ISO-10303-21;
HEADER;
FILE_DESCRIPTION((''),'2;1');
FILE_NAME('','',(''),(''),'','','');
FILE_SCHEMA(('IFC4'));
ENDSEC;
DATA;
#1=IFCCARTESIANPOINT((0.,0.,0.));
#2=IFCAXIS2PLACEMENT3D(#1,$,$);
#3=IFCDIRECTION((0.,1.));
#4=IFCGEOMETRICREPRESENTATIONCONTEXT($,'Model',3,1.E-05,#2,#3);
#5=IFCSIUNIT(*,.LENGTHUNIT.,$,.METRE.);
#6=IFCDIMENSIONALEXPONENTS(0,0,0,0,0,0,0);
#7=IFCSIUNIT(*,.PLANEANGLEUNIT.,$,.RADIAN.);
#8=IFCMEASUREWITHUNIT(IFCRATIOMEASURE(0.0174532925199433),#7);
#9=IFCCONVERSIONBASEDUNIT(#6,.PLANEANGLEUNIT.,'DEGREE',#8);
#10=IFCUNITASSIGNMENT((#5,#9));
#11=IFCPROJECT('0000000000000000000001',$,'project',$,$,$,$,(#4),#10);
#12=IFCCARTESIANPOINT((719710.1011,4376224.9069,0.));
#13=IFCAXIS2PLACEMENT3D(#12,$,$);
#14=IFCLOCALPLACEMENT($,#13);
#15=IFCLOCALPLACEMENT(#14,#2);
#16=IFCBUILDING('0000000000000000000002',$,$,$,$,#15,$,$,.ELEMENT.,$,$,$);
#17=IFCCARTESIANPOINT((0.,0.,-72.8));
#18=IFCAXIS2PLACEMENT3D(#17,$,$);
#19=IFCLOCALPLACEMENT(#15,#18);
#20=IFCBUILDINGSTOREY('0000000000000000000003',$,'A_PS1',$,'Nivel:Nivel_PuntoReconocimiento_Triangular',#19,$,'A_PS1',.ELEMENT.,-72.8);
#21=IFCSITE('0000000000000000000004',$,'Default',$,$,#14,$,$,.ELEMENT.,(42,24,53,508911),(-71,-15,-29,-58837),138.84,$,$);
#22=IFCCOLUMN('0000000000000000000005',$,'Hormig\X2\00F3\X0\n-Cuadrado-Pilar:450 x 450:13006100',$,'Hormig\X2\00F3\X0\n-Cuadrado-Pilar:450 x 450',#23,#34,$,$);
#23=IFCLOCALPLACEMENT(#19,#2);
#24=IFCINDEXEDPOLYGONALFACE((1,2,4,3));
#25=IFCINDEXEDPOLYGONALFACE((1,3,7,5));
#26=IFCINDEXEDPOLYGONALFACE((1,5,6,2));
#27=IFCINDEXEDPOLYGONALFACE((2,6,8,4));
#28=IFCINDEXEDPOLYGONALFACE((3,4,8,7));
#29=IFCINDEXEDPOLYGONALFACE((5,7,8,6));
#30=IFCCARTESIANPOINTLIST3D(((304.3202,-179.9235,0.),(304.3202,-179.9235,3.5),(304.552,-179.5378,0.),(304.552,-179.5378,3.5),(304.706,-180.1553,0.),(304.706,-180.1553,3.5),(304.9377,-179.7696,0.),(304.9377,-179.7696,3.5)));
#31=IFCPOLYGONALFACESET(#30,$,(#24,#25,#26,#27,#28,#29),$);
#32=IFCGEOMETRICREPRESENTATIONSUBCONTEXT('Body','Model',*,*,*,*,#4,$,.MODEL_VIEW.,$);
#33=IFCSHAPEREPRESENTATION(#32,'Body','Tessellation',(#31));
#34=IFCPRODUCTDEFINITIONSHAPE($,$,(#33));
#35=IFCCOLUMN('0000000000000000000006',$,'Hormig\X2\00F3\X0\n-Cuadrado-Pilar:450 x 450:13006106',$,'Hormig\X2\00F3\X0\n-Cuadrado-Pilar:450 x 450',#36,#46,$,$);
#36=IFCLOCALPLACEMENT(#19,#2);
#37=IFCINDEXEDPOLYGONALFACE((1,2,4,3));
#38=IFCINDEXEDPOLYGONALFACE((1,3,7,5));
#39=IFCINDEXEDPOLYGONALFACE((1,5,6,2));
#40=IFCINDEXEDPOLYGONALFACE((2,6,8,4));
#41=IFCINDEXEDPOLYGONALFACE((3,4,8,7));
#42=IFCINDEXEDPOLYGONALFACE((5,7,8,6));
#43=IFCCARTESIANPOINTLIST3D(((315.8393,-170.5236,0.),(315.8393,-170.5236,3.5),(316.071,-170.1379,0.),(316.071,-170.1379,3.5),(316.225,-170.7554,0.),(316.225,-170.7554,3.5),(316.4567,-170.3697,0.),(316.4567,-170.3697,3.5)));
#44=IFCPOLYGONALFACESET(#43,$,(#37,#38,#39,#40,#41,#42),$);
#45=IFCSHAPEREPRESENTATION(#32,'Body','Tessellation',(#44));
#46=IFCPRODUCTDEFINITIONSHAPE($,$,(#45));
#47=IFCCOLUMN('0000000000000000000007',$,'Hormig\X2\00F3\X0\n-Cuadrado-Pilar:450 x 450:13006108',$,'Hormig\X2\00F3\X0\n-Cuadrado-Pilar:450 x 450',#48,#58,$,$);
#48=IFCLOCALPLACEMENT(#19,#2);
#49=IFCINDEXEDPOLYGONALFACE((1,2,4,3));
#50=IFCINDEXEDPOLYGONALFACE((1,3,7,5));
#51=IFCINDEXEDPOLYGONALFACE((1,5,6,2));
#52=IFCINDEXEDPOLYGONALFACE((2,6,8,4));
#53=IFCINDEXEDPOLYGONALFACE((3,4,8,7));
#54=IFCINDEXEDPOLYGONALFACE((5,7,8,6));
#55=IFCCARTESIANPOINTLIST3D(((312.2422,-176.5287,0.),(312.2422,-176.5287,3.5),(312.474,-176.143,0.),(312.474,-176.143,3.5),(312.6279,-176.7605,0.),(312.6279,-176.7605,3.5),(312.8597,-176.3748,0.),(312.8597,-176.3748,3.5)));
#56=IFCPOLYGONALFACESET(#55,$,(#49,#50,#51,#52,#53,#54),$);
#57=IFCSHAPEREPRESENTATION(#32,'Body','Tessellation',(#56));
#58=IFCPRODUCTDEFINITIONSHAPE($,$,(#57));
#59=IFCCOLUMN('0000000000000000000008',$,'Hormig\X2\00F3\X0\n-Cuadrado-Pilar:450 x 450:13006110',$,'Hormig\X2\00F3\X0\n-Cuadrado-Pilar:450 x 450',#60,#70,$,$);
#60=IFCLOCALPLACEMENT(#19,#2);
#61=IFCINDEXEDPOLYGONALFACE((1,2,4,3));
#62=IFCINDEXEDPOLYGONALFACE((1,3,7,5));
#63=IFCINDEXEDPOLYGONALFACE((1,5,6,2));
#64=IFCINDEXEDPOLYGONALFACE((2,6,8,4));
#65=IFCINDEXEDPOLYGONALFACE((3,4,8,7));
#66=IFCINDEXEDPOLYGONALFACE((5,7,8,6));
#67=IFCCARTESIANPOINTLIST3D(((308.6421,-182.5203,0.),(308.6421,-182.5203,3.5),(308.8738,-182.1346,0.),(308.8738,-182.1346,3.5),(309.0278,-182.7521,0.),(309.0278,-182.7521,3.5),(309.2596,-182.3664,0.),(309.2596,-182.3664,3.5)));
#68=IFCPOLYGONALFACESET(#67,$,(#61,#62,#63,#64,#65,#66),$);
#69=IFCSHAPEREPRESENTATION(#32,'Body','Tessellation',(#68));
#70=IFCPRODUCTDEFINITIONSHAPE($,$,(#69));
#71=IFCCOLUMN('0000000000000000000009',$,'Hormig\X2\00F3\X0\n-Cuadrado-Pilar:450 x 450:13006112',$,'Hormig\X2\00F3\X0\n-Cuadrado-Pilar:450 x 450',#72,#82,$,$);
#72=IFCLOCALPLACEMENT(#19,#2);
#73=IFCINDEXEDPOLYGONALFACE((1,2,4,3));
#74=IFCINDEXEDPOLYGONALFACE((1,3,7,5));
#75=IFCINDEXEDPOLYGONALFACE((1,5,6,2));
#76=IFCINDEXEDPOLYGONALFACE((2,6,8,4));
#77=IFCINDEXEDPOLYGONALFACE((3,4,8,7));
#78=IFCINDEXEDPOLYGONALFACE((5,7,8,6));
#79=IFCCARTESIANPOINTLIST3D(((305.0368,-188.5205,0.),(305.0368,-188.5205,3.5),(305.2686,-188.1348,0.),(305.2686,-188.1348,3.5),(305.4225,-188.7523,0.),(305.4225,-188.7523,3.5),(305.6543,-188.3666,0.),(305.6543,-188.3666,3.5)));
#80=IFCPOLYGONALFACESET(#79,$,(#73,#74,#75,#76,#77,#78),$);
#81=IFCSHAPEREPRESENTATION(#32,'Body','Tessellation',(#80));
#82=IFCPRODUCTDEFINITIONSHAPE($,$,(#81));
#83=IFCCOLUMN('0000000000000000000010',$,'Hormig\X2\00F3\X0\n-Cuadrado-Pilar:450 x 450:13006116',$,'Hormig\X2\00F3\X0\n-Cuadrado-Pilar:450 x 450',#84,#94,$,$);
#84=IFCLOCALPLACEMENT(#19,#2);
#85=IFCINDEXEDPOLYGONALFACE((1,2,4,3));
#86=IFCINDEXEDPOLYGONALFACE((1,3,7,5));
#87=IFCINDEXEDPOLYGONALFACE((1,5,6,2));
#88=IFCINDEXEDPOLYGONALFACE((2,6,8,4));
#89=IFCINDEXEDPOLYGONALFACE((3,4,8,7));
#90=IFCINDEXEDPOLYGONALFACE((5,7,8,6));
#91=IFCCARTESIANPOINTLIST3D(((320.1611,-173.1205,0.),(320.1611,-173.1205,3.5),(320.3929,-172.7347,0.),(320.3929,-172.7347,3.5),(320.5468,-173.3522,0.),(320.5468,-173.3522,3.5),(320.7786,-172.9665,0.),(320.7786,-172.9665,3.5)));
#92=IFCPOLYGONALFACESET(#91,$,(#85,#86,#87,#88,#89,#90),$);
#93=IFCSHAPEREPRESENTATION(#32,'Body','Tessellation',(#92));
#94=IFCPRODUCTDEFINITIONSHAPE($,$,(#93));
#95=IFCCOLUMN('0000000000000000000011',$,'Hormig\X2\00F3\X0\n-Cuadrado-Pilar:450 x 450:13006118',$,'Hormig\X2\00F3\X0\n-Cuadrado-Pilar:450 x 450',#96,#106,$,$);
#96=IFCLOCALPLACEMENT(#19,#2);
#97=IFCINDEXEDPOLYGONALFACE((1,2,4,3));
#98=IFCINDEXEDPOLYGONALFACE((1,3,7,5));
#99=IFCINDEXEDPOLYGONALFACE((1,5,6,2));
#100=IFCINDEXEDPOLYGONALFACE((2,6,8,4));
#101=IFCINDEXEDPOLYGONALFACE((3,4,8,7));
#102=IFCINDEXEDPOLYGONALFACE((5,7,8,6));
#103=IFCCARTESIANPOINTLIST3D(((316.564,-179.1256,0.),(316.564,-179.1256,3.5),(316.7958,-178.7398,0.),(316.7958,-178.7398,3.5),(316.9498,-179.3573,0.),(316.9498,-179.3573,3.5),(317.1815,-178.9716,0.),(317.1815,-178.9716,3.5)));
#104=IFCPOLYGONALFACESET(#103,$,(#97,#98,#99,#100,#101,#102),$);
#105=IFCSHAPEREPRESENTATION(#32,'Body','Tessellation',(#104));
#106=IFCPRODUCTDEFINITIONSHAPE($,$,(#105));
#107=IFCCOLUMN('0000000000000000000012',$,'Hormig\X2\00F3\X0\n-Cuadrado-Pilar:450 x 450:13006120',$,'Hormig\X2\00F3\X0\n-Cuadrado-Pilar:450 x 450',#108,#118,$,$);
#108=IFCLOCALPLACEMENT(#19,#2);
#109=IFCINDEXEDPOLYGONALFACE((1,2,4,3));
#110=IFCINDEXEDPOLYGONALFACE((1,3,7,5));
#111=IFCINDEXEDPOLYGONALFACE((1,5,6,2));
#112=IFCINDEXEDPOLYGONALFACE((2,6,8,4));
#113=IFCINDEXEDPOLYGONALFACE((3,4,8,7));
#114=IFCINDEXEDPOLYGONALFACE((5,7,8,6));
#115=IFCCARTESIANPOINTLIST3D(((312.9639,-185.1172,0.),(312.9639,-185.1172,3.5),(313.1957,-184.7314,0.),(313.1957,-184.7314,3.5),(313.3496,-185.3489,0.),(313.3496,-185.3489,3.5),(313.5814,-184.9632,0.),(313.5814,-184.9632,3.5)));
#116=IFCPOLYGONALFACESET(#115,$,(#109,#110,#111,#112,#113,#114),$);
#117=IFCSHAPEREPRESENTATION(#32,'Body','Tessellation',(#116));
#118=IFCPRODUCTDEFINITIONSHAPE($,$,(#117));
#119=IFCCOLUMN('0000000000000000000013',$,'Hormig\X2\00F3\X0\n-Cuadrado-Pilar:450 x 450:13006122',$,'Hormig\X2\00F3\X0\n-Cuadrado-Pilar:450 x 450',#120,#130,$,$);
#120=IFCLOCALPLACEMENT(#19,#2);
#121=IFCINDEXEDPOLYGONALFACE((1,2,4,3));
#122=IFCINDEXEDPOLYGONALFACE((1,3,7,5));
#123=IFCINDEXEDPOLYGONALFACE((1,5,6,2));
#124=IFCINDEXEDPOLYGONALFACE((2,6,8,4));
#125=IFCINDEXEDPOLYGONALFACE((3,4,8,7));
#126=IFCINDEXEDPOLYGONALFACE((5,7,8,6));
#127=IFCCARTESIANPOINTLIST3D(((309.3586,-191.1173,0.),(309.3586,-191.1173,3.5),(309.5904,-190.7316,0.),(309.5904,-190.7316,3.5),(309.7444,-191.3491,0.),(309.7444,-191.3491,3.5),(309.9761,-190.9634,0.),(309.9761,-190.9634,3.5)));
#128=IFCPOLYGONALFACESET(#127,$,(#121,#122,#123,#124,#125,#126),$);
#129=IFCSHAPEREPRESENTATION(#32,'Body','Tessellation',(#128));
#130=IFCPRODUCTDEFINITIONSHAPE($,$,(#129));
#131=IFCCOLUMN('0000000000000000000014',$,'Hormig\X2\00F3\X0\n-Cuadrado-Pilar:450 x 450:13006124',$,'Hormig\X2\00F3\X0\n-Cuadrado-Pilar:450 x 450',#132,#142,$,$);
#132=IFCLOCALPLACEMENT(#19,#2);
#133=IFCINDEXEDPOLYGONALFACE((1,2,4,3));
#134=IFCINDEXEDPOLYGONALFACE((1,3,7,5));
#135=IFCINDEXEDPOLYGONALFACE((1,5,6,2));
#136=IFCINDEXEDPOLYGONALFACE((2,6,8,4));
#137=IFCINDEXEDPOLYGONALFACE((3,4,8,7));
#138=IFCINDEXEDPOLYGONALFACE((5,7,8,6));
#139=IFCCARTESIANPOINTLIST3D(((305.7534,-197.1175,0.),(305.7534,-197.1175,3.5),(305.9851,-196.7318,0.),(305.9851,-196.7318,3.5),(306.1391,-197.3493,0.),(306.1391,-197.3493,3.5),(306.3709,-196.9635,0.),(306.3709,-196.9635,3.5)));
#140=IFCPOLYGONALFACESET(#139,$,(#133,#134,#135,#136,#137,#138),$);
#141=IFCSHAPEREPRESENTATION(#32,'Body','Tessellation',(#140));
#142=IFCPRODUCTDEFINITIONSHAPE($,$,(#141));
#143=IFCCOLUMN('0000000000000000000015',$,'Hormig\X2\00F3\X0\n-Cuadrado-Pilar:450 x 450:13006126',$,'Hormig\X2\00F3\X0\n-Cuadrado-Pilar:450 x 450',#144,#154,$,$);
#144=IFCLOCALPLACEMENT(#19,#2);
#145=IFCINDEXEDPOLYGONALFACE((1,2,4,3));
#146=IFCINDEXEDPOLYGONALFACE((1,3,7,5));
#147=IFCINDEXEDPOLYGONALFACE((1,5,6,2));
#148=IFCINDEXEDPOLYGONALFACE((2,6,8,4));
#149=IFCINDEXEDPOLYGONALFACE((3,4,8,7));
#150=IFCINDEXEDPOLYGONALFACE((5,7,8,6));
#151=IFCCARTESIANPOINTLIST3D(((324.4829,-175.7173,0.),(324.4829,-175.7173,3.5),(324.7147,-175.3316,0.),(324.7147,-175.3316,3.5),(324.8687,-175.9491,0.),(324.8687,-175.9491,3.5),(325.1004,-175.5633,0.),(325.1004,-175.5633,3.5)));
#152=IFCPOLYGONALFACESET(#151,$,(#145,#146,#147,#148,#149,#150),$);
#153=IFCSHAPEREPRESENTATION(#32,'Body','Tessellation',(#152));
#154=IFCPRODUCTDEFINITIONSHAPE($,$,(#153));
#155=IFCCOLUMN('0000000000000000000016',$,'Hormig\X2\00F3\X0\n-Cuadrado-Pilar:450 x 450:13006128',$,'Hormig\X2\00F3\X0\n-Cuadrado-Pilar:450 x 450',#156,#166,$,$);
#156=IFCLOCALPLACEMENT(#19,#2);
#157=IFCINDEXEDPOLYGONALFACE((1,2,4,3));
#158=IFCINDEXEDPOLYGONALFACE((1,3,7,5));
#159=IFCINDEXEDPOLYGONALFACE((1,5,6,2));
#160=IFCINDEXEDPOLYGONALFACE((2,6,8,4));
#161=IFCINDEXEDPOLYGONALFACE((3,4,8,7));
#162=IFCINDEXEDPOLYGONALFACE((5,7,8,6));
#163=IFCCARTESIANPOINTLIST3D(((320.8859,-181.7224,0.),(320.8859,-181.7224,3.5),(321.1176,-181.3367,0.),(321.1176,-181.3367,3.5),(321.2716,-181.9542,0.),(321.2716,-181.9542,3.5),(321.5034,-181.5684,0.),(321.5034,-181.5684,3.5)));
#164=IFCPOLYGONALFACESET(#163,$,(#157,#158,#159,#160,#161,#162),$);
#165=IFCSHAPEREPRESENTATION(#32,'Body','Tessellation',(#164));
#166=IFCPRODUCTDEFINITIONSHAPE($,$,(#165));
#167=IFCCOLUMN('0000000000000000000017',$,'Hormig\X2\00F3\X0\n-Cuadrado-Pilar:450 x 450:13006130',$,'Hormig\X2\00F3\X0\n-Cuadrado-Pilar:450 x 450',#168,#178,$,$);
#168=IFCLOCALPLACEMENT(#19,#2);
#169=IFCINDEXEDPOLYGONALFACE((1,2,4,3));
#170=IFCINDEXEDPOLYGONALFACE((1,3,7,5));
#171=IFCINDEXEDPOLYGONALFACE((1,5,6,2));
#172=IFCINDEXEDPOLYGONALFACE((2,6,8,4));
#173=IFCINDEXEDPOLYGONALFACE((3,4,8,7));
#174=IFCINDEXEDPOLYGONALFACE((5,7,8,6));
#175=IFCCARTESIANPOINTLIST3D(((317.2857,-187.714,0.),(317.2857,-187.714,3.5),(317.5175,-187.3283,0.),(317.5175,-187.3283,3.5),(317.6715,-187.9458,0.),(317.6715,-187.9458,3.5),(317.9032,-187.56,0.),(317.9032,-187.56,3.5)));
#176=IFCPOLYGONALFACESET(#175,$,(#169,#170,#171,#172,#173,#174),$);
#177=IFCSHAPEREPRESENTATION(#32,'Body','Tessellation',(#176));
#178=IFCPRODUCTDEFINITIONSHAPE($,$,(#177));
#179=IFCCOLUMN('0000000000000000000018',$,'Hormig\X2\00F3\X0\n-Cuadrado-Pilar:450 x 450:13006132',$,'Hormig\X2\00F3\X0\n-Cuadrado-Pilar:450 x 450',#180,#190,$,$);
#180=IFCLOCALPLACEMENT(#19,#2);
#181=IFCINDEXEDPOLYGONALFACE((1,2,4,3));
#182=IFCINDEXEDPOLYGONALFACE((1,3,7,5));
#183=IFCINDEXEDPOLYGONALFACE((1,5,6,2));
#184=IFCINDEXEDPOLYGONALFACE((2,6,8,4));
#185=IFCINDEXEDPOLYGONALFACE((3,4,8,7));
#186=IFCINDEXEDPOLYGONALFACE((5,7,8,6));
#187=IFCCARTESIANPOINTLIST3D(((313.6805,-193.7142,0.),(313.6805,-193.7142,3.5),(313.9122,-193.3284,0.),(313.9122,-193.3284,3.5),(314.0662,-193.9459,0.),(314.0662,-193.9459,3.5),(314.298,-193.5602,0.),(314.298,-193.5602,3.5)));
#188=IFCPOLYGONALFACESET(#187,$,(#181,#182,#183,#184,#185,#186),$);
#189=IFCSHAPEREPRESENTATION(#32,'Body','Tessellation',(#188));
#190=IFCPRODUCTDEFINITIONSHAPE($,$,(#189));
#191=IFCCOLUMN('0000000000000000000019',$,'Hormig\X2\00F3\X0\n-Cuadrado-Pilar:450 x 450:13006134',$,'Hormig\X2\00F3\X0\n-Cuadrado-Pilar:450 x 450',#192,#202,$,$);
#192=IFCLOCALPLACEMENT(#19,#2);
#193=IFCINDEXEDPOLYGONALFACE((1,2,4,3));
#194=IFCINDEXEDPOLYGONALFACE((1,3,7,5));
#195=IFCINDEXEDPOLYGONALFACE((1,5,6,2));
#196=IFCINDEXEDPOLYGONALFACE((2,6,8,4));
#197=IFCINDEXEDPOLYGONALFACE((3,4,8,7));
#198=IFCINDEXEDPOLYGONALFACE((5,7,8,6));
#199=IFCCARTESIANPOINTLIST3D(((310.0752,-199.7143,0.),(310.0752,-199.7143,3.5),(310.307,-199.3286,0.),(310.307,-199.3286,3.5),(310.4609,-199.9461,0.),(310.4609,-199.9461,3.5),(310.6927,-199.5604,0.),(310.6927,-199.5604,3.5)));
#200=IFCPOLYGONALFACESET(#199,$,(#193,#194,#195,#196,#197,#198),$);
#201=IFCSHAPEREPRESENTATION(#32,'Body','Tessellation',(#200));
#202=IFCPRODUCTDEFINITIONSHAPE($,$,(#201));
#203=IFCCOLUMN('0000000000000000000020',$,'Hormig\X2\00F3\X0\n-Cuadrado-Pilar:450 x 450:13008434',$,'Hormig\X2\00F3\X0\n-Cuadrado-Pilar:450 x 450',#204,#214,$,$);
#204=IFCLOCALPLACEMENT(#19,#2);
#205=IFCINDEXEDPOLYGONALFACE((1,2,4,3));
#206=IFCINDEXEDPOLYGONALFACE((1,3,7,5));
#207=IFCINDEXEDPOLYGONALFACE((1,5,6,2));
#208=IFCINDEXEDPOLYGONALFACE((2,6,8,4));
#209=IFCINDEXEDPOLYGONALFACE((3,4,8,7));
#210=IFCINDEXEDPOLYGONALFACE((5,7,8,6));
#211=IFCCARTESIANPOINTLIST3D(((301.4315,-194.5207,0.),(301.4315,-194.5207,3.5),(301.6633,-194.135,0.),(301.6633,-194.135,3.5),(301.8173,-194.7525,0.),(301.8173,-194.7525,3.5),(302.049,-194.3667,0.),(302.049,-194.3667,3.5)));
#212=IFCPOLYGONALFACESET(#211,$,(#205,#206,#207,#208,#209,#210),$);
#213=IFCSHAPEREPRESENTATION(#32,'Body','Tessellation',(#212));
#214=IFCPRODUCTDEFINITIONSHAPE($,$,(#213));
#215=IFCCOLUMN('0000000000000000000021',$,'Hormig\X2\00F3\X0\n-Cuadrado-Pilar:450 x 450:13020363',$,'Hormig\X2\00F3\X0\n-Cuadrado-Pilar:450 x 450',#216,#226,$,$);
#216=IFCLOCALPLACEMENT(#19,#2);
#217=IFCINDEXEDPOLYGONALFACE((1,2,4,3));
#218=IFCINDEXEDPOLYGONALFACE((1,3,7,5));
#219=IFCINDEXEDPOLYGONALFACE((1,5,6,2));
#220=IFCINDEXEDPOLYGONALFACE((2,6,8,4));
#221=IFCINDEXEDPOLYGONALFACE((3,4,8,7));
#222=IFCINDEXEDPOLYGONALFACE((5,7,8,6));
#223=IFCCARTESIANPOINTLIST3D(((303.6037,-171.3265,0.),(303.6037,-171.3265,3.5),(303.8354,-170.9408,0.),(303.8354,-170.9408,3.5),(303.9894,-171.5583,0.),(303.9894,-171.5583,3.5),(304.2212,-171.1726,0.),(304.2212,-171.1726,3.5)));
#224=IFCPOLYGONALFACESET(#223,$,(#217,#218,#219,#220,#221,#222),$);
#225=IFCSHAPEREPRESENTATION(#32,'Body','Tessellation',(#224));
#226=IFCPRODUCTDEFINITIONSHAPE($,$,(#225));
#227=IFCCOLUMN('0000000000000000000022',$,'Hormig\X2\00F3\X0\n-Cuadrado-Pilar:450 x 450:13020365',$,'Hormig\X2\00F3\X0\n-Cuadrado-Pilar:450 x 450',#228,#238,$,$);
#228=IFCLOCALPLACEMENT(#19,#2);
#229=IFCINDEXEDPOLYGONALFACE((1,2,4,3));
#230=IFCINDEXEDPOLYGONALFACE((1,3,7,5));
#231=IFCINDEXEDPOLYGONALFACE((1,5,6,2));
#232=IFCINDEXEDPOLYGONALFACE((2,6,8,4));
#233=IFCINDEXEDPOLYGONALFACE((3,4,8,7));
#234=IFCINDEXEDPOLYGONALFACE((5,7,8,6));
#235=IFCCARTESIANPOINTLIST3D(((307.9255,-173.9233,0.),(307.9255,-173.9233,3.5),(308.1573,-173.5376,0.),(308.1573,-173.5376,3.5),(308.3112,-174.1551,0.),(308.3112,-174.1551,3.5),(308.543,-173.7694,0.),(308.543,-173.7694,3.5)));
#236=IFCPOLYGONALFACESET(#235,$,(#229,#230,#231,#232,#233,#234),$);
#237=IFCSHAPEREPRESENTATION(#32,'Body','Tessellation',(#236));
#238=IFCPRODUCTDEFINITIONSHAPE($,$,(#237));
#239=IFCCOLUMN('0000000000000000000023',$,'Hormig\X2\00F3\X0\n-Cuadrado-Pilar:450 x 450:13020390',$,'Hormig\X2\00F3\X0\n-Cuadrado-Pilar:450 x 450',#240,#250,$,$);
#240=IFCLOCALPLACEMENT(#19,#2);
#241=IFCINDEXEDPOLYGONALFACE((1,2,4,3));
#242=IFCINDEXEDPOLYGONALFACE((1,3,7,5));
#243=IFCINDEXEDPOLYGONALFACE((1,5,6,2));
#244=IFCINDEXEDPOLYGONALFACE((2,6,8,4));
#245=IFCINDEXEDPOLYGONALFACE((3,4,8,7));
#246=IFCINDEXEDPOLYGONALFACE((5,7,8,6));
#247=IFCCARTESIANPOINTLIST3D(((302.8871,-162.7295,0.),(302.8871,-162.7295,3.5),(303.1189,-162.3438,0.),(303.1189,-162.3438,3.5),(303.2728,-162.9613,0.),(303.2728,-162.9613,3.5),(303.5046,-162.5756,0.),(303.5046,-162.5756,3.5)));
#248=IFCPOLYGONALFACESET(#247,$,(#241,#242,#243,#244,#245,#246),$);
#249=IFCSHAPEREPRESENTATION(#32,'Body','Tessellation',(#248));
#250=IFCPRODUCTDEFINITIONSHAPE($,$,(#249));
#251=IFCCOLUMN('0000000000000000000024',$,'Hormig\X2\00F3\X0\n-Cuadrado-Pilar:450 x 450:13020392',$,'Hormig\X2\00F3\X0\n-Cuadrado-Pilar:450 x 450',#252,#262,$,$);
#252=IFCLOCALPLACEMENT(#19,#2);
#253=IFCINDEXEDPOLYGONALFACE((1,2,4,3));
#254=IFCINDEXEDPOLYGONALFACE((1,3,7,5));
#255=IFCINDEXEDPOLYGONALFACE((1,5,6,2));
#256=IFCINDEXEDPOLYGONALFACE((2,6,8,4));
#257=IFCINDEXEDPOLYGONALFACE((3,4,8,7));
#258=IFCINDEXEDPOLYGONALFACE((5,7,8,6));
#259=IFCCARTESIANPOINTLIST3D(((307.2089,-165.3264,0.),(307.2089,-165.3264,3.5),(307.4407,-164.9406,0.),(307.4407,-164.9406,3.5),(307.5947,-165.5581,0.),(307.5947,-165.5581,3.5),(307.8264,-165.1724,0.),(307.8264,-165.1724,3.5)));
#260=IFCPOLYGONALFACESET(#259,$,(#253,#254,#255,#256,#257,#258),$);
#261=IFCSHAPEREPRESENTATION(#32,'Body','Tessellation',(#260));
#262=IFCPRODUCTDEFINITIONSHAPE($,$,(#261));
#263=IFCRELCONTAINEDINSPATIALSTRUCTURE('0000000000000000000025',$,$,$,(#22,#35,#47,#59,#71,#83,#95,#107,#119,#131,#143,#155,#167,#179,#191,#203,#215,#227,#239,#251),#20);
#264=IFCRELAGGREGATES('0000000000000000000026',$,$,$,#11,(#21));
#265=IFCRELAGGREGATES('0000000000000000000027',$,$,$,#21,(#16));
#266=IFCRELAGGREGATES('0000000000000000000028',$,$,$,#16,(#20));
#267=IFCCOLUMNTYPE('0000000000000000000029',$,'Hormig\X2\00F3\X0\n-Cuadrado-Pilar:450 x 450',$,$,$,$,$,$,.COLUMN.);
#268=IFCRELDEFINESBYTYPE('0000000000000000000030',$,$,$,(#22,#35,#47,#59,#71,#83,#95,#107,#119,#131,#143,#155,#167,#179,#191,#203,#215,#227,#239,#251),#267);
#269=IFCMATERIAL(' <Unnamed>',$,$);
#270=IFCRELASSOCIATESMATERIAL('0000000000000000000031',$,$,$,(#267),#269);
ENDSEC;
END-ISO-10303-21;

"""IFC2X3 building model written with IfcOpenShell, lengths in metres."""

from ifc_helpers import new_model, entity, si_unit, converted_unit, direction, frame, origin, origin_2d_with_axis, place, context, subcontext, project, spatial, rectangle, extrude, source, transform, mapped, material, type_object, type_shapes, element, save


model = new_model("IFC2X3")

# Units and contexts
model_context = context("Model", 3, precision=1e-05, world=origin(), true_north=direction((0.0, 1.0)))
body_context = subcontext(model_context, "Body", "Model", "MODEL_VIEW")
ifc_project = project(units=[si_unit("LENGTHUNIT", "METRE"), converted_unit("PLANEANGLEUNIT", "DEGREE", entity("IfcRatioMeasure", 0.0174532925199433), si_unit("PLANEANGLEUNIT", "RADIAN"), dimensions=[0, 0, 0, 0, 0, 0, 0])], contexts=[model_context])

# Site, building, storey
site_placement = place(None, frame((719710.1011, 4376224.9069, 0.0)))
site = spatial("IfcSite", under=ifc_project, at=site_placement, Name="Default", CompositionType="ELEMENT", RefLatitude=(42, 24, 53, 508911), RefLongitude=(-71, -15, -29, -58837), RefElevation=138.84)
building_placement = place(site_placement, origin())
building = spatial("IfcBuilding", under=site, at=building_placement, CompositionType="ELEMENT")
storey_placement = place(building_placement, frame((0.0, 0.0, -72.8)))
storey = spatial("IfcBuildingStorey", under=building, at=storey_placement, Name="A_PS1", ObjectType="Nivel:Nivel_PuntoReconocimiento_Triangular", LongName="A_PS1", CompositionType="ELEMENT", Elevation=-72.8)

# Columns
ifc_material = material(Name=" <Unnamed>")
column_type = type_object("IfcColumnType", Name="Hormigón-Cuadrado-Pilar:450 x 450", PredefinedType="COLUMN", material=ifc_material)
shared_shape = source(origin(), body_context, "Body", "SweptSolid", [
    extrude(rectangle(XDim=0.45, YDim=0.45, at=origin_2d_with_axis()), frame((0.0, 0.0, -72.8), z_axis=(0.0, 0.0, 1.0), x_axis=(0.0, -1.0, 0.0)), (0.0, 0.0, 1.0), 3.5),
])
type_shapes(column_type, [shared_shape])
for number, where, z_axis, x_axis, name in (
    (1, (304.629, -179.8465, 72.8), (0.0, 0.0, 1.0), (0.857167, -0.515038, 0.0), "Hormigón-Cuadrado-Pilar:450 x 450:13006100"),
    (2, (316.148, -170.4467, 72.8), (0.0, 0.0, 1.0), (0.857167, -0.515038, 0.0), "Hormigón-Cuadrado-Pilar:450 x 450:13006106"),
    (3, (312.5509, -176.4518, 72.8), (0.0, 0.0, 1.0), (0.857167, -0.515038, 0.0), "Hormigón-Cuadrado-Pilar:450 x 450:13006108"),
    (4, (308.9508, -182.4434, 72.8), (0.0, 0.0, 1.0), (0.857167, -0.515038, 0.0), "Hormigón-Cuadrado-Pilar:450 x 450:13006110"),
    (5, (305.3456, -188.4435, 72.8), (0.0, 0.0, 1.0), (0.857167, -0.515038, 0.0), "Hormigón-Cuadrado-Pilar:450 x 450:13006112"),
    (6, (320.4698, -173.0435, 72.8), (0.0, 0.0, 1.0), (0.857167, -0.515038, 0.0), "Hormigón-Cuadrado-Pilar:450 x 450:13006116"),
    (7, (316.8728, -179.0486, 72.8), (0.0, 0.0, 1.0), (0.857167, -0.515038, 0.0), "Hormigón-Cuadrado-Pilar:450 x 450:13006118"),
    (8, (313.2727, -185.0402, 72.8), (0.0, 0.0, 1.0), (0.857167, -0.515038, 0.0), "Hormigón-Cuadrado-Pilar:450 x 450:13006120"),
    (9, (309.6674, -191.0404, 72.8), (0.0, 0.0, 1.0), (0.857167, -0.515038, 0.0), "Hormigón-Cuadrado-Pilar:450 x 450:13006122"),
    (10, (306.0621, -197.0405, 72.8), (0.0, 0.0, 1.0), (0.857167, -0.515038, 0.0), "Hormigón-Cuadrado-Pilar:450 x 450:13006124"),
    (11, (324.7917, -175.6403, 72.8), (0.0, 0.0, 1.0), (0.857167, -0.515038, 0.0), "Hormigón-Cuadrado-Pilar:450 x 450:13006126"),
    (12, (321.1946, -181.6454, 72.8), (0.0, 0.0, 1.0), (0.857167, -0.515038, 0.0), "Hormigón-Cuadrado-Pilar:450 x 450:13006128"),
    (13, (317.5945, -187.637, 72.8), (0.0, 0.0, 1.0), (0.857167, -0.515038, 0.0), "Hormigón-Cuadrado-Pilar:450 x 450:13006130"),
    (14, (313.9892, -193.6372, 72.8), (0.0, 0.0, 1.0), (0.857167, -0.515038, 0.0), "Hormigón-Cuadrado-Pilar:450 x 450:13006132"),
    (15, (310.384, -199.6373, 72.8), (0.0, 0.0, 1.0), (0.857167, -0.515038, 0.0), "Hormigón-Cuadrado-Pilar:450 x 450:13006134"),
    (16, (301.7403, -194.4437, 72.8), (0.0, 0.0, 1.0), (0.857167, -0.515038, 0.0), "Hormigón-Cuadrado-Pilar:450 x 450:13008434"),
    (17, (303.9124, -171.2495, 72.8), (0.0, 0.0, 1.0), (0.857167, -0.515038, 0.0), "Hormigón-Cuadrado-Pilar:450 x 450:13020363"),
    (18, (308.2342, -173.8464, 72.8), (0.0, 0.0, 1.0), (0.857167, -0.515038, 0.0), "Hormigón-Cuadrado-Pilar:450 x 450:13020365"),
    (19, (303.1958, -162.6526, 72.8), (0.0, 0.0, 1.0), (0.857167, -0.515038, 0.0), "Hormigón-Cuadrado-Pilar:450 x 450:13020390"),
    (20, (307.5177, -165.2494, 72.8), (0.0, 0.0, 1.0), (0.857167, -0.515038, 0.0), "Hormigón-Cuadrado-Pilar:450 x 450:13020392"),
):
    element("IfcColumn", number, at=place(storey_placement, frame(where, z_axis=z_axis, x_axis=x_axis)), inside=storey, type_object=column_type, Name=name, ObjectType="Hormigón-Cuadrado-Pilar:450 x 450", context=body_context, shape_type="MappedRepresentation", body=[
        mapped(shared_shape, transform((0.0, 0.0, 0.0), scale=1.0)),
    ])

save(model, "model.ifc")
